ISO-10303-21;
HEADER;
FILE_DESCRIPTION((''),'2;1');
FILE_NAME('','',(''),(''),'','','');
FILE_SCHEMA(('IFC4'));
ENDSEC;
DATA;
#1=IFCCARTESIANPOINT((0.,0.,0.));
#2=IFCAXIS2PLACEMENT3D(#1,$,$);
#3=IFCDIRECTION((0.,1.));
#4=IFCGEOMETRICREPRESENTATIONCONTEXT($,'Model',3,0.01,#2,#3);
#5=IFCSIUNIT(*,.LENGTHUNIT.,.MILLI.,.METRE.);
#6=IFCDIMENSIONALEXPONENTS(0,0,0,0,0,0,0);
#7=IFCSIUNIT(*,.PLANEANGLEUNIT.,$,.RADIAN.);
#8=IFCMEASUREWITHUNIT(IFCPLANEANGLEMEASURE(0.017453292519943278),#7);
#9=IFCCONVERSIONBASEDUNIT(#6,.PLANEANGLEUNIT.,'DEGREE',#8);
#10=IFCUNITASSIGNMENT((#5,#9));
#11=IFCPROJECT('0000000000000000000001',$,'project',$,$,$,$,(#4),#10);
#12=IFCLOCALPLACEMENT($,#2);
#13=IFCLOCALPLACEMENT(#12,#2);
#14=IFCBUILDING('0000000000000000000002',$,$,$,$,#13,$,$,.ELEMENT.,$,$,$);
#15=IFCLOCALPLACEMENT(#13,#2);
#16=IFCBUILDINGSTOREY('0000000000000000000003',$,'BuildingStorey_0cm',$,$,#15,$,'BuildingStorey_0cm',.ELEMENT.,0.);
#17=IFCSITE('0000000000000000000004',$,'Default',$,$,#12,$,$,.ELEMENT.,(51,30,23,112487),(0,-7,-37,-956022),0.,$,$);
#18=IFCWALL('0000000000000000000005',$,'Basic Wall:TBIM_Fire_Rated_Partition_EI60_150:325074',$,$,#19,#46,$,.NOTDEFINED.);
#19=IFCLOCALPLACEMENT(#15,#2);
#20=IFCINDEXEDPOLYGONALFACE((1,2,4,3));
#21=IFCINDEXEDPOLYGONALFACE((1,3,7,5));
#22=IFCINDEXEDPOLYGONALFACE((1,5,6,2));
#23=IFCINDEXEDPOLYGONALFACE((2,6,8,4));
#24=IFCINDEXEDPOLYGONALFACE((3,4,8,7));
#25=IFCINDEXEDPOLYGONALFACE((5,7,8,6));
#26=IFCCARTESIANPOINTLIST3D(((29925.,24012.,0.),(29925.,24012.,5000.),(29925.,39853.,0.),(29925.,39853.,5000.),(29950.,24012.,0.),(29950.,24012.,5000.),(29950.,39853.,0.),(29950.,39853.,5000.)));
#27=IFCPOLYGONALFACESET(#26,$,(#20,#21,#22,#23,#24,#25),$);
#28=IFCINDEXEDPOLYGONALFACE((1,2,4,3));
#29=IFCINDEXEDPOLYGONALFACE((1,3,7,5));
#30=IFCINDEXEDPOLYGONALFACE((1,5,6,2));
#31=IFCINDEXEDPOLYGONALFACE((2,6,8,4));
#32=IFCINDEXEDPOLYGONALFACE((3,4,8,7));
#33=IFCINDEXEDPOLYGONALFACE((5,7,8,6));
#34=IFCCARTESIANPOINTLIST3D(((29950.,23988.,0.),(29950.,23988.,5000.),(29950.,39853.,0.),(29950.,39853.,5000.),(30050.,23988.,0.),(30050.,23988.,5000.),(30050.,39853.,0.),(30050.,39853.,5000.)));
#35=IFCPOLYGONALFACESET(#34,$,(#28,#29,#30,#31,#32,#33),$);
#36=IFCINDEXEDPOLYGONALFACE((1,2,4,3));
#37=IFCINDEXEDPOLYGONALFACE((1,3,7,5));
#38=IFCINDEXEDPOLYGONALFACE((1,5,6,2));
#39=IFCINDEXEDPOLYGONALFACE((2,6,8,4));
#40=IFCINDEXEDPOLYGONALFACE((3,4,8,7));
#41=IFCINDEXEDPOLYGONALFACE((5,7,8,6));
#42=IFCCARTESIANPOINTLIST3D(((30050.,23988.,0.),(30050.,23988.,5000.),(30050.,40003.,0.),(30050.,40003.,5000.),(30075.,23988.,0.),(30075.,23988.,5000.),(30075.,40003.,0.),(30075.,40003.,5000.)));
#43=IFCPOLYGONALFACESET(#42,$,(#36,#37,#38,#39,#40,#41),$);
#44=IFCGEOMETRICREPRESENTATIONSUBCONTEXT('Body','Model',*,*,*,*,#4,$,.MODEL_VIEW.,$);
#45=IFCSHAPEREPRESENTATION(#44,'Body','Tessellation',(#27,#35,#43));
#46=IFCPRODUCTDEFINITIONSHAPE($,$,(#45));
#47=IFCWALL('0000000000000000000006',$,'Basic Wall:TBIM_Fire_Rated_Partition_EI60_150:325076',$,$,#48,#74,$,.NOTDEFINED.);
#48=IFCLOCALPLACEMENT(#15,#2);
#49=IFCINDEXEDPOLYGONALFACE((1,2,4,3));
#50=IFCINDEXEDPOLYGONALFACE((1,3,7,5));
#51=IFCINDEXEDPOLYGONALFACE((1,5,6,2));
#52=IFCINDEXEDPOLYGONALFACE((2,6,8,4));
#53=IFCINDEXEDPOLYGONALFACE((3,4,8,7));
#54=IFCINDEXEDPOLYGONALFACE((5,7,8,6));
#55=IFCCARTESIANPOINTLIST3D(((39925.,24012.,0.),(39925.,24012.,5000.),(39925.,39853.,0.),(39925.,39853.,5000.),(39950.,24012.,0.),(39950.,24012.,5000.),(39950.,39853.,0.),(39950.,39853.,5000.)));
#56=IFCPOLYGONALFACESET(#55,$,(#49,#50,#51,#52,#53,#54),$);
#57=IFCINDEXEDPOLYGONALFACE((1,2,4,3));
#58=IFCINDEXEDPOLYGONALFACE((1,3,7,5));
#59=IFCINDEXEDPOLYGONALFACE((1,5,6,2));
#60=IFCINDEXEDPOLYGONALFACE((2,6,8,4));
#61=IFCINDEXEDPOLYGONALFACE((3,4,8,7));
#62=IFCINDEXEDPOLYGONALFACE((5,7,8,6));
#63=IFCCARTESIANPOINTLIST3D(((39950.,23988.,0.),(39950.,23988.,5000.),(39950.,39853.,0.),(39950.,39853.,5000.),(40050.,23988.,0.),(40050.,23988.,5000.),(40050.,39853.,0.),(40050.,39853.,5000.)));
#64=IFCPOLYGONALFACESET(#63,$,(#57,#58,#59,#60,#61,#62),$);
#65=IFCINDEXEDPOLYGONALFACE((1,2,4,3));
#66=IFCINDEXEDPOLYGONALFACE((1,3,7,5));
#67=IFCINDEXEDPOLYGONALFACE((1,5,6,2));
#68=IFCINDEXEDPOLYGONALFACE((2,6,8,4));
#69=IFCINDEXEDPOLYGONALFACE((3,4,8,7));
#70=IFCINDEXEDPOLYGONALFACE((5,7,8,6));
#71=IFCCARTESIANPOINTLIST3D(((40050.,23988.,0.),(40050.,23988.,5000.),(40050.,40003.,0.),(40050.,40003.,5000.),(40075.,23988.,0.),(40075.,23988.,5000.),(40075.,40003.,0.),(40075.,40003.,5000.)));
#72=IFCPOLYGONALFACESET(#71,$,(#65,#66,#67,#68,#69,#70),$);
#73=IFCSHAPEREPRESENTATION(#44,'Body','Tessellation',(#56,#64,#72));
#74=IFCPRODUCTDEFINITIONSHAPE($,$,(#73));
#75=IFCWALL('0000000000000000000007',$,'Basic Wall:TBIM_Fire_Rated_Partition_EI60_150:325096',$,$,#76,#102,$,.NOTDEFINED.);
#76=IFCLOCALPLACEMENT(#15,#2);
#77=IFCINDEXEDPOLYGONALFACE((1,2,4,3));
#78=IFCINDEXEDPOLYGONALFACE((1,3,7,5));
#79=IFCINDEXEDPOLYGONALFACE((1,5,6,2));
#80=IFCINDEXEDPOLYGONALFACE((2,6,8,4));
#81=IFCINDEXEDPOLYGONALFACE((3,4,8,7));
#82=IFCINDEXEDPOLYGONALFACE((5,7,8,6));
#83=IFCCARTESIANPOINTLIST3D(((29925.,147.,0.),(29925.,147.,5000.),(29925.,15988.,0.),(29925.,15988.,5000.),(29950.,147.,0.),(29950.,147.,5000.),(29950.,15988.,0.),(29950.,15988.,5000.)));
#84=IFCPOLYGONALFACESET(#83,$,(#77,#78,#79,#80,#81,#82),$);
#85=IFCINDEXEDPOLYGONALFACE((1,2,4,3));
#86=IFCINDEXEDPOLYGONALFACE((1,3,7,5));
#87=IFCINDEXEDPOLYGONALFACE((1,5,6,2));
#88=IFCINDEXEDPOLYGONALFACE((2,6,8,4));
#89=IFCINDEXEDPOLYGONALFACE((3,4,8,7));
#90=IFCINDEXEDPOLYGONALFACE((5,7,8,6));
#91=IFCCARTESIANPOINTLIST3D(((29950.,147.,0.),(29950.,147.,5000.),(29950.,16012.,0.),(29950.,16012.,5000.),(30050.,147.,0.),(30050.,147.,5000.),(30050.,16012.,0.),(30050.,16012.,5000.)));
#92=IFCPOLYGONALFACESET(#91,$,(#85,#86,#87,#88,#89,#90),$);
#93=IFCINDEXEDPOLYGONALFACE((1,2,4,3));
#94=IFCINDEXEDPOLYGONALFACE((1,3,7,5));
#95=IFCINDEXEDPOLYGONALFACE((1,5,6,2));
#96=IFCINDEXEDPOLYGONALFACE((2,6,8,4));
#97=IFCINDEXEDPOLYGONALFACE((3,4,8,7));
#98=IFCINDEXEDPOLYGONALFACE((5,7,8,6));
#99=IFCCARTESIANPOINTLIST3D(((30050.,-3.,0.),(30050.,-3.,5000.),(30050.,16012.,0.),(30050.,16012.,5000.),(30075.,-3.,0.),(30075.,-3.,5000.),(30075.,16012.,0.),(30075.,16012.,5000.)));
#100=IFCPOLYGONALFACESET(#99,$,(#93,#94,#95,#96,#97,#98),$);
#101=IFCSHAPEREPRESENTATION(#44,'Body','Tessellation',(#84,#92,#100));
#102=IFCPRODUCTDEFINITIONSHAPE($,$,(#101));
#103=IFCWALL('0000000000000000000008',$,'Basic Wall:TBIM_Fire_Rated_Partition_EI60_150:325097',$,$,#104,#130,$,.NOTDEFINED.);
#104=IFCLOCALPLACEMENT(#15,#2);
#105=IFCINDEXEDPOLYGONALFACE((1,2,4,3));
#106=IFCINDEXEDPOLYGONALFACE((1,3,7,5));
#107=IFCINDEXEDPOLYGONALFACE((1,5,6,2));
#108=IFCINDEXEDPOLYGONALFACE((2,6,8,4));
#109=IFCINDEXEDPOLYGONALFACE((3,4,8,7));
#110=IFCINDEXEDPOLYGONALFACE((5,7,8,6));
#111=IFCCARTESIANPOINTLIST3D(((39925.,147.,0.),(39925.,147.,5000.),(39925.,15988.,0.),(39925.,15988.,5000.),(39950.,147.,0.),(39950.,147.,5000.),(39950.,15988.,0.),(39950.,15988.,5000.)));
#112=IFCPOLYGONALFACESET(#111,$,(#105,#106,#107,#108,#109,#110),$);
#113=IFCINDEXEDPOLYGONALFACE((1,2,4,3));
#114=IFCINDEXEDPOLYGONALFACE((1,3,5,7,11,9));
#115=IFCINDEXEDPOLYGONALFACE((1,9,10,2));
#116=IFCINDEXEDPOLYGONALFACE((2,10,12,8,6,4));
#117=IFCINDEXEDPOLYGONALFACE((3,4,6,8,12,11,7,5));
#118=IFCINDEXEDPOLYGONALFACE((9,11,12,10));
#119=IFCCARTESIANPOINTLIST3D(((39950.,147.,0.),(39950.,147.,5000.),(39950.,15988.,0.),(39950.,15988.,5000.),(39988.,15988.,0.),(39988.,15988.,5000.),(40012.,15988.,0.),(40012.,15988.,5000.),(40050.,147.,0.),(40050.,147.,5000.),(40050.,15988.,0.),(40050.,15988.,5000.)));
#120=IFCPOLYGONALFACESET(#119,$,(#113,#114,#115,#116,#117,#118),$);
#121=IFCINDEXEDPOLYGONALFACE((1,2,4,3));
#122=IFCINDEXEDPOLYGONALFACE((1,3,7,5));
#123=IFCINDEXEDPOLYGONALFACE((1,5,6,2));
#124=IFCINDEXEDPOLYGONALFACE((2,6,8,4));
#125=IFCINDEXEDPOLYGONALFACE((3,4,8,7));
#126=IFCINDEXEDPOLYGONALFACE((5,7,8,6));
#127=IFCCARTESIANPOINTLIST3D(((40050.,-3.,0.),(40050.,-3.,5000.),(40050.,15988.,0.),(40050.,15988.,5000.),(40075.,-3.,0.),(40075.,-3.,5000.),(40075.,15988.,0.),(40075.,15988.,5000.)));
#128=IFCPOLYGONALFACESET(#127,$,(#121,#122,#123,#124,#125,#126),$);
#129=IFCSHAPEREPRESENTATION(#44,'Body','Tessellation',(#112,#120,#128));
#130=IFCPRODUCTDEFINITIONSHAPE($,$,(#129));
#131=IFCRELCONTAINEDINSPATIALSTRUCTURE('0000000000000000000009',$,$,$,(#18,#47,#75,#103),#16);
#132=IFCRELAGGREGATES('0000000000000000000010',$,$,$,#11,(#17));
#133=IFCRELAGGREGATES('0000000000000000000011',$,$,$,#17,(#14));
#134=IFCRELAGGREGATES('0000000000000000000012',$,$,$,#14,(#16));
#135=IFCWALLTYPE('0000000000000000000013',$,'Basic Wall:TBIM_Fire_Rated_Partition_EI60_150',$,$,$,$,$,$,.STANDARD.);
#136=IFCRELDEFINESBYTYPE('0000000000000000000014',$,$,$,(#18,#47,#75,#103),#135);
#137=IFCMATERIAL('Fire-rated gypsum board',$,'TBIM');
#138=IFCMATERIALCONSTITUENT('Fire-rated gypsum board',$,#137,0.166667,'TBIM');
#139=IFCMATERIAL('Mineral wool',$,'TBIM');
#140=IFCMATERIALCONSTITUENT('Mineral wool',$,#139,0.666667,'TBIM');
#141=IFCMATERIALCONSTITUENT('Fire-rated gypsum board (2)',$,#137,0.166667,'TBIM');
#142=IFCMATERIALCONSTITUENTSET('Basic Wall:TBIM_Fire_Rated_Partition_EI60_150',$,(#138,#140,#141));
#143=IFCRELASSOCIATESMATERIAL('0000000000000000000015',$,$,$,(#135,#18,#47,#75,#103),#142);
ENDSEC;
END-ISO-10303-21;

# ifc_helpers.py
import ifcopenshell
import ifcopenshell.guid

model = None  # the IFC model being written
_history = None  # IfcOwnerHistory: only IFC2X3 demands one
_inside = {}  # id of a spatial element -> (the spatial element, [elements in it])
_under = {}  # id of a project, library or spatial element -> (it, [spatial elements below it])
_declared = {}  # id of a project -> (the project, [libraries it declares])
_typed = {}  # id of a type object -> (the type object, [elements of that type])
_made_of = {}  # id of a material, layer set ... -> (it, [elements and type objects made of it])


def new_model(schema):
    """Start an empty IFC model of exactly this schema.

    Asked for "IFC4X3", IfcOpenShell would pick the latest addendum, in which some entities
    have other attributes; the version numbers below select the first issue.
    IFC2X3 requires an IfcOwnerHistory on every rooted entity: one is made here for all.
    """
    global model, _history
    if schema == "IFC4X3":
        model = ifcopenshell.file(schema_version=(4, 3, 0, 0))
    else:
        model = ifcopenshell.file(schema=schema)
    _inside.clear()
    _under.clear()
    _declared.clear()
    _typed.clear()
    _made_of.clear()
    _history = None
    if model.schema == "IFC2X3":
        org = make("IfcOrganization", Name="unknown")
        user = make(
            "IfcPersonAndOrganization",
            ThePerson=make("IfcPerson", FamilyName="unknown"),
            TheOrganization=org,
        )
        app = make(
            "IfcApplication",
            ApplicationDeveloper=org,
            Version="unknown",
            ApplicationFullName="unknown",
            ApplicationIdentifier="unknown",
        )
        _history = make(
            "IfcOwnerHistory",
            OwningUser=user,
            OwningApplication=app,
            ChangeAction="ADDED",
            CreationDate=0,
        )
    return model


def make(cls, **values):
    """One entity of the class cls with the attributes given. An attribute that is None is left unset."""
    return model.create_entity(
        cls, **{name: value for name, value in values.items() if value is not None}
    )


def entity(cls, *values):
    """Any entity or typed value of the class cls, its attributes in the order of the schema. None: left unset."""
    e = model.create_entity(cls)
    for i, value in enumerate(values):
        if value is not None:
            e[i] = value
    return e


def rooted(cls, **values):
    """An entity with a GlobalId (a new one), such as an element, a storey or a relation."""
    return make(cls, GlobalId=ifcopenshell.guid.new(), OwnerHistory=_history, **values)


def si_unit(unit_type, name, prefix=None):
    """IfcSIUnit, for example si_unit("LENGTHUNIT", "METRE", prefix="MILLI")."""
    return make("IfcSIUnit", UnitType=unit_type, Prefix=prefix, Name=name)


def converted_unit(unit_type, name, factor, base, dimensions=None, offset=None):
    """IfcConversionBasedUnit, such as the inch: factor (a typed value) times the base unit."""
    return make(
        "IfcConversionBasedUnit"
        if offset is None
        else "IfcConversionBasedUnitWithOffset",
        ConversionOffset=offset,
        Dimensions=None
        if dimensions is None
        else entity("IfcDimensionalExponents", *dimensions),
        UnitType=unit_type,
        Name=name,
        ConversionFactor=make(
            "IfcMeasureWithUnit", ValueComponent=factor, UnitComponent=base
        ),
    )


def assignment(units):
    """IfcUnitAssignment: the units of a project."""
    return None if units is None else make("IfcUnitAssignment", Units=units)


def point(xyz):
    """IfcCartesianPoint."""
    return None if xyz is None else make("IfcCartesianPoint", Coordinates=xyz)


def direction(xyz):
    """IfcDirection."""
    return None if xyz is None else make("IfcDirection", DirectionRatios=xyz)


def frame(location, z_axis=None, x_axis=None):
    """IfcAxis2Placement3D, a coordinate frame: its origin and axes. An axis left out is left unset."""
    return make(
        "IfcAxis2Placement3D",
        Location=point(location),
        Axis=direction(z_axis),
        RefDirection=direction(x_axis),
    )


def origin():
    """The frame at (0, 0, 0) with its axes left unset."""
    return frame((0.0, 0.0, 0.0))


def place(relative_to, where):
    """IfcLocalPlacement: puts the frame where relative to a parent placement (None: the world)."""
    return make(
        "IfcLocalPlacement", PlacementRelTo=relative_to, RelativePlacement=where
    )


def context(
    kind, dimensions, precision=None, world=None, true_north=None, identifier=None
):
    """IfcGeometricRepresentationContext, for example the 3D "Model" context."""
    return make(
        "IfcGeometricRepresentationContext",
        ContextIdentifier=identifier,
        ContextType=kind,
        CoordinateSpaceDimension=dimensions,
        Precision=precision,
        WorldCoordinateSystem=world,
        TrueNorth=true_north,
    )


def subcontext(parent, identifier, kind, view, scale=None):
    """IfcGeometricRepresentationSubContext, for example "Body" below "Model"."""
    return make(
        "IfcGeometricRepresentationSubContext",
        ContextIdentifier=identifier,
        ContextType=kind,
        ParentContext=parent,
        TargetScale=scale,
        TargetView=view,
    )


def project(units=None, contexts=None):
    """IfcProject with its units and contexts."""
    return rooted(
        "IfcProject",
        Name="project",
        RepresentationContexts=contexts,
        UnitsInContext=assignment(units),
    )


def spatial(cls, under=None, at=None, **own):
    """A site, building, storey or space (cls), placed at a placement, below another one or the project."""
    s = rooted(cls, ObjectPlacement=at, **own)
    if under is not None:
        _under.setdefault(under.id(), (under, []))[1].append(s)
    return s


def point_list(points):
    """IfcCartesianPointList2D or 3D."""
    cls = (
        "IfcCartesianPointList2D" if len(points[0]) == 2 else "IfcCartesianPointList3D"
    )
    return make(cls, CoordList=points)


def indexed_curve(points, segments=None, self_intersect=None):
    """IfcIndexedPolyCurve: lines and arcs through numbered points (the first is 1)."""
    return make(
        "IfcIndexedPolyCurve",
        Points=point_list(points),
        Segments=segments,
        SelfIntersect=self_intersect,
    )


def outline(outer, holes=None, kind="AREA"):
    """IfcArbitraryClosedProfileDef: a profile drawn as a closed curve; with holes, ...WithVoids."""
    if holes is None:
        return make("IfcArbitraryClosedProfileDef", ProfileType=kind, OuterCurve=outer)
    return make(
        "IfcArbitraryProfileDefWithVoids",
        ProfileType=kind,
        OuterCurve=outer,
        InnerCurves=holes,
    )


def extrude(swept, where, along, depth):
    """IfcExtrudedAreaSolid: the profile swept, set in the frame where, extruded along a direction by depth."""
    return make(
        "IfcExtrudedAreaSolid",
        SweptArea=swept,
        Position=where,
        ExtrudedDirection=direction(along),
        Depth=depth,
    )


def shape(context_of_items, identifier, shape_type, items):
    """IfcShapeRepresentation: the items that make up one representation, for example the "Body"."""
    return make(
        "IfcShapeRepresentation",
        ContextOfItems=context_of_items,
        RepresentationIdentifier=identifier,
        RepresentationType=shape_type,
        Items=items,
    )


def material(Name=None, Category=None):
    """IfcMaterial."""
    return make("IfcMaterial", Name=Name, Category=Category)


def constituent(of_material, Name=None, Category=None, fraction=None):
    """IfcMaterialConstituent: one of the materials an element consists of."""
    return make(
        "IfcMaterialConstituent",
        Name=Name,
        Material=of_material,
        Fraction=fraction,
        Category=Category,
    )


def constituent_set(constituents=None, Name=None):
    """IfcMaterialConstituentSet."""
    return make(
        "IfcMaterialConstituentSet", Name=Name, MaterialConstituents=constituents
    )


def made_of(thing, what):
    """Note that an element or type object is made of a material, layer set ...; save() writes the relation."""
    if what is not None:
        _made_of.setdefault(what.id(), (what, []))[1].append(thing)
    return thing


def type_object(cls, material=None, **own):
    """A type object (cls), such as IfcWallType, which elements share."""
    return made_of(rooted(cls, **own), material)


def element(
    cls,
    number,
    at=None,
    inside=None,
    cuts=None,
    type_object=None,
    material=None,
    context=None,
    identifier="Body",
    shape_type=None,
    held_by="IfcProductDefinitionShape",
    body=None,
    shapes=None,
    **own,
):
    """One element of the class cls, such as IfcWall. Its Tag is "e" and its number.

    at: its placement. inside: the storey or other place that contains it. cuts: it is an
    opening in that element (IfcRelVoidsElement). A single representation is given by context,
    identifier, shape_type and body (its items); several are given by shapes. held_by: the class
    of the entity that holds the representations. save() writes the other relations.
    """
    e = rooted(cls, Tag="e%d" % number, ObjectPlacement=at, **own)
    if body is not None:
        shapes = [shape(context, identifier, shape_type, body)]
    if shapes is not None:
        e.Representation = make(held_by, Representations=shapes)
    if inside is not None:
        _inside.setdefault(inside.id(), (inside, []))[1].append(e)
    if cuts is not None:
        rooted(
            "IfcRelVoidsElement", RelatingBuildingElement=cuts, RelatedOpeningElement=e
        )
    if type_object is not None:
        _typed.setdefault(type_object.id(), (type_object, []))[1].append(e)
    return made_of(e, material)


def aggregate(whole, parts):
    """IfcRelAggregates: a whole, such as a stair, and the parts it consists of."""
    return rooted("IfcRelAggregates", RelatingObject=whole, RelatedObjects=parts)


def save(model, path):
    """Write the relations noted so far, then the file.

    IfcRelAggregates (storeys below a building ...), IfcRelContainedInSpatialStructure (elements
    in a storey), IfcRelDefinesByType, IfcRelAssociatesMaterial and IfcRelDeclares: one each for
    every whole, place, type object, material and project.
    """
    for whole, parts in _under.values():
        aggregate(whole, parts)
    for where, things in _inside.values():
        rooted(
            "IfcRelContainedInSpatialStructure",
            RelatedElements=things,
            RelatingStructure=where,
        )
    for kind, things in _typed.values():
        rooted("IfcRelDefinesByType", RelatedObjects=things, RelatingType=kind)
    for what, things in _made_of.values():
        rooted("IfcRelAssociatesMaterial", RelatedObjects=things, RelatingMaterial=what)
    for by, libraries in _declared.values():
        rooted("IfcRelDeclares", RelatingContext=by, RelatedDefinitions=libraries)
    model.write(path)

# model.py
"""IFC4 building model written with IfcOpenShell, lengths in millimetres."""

from ifc_helpers import new_model, entity, si_unit, converted_unit, direction, frame, origin, place, context, subcontext, project, spatial, indexed_curve, outline, extrude, material, constituent, constituent_set, type_object, element, save


model = new_model("IFC4")

# Units and contexts
model_context = context("Model", 3, precision=0.01, world=origin(), true_north=direction((0.0, 1.0)))
body_context = subcontext(model_context, "Body", "Model", "MODEL_VIEW")
ifc_project = project(units=[si_unit("LENGTHUNIT", "METRE", prefix="MILLI"), converted_unit("PLANEANGLEUNIT", "DEGREE", entity("IfcPlaneAngleMeasure", 0.017453292519943278), si_unit("PLANEANGLEUNIT", "RADIAN"), dimensions=[0, 0, 0, 0, 0, 0, 0])], contexts=[model_context])

# Site, building, storey
site_placement = place(None, origin())
site = spatial("IfcSite", under=ifc_project, at=site_placement, Name="Default", CompositionType="ELEMENT", RefLatitude=(51, 30, 23, 112487), RefLongitude=(0, -7, -37, -956022), RefElevation=0.0)
building_placement = place(site_placement, origin())
building = spatial("IfcBuilding", under=site, at=building_placement, CompositionType="ELEMENT")
storey_placement = place(building_placement, origin())
storey = spatial("IfcBuildingStorey", under=building, at=storey_placement, Name="BuildingStorey_0cm", LongName="BuildingStorey_0cm", CompositionType="ELEMENT", Elevation=0.0)

# Shared definitions
ifc_material_1 = material(Name="Mineral wool", Category="TBIM")

# Walls
ifc_material_2 = material(Name="Fire-rated gypsum board", Category="TBIM")
ifc_constituent_1 = constituent(ifc_material_2, Name="Fire-rated gypsum board", Category="TBIM", fraction=0.166667)
ifc_constituent_2 = constituent(ifc_material_1, Name="Mineral wool", Category="TBIM", fraction=0.666667)
ifc_constituent_3 = constituent(ifc_material_2, Name="Fire-rated gypsum board (2)", Category="TBIM", fraction=0.166667)
ifc_constituent_set_1 = constituent_set(constituents=[ifc_constituent_1, ifc_constituent_2, ifc_constituent_3], Name="Basic Wall:TBIM_Fire_Rated_Partition_EI60_150")
wall_type_1 = type_object("IfcWallType", Name="Basic Wall:TBIM_Fire_Rated_Partition_EI60_150", PredefinedType="STANDARD", material=ifc_constituent_set_1)
wall_1_placement = place(storey_placement, frame((30000.0, 24012.0, 0.0), z_axis=(0.0, 0.0, 1.0), x_axis=(0.0, 1.0, 0.0)))
element("IfcWall", 1, at=wall_1_placement, inside=storey, type_object=wall_type_1, material=ifc_constituent_set_1, Name="Basic Wall:TBIM_Fire_Rated_Partition_EI60_150:325074", PredefinedType="NOTDEFINED", context=body_context, shape_type="SweptSolid", body=[
    extrude(outline(indexed_curve([(-12.5, -7920.5), (12.5, -7920.5), (12.5, 7920.5), (-12.5, 7920.5), (-12.5, -7920.5)], self_intersect=False)), frame((7920.5, 62.5, 0.0), z_axis=(0.0, 0.0, 1.0), x_axis=(0.0, -1.0, 0.0)), (0.0, 0.0, 1.0), 5000.0),
    extrude(outline(indexed_curve([(-7932.5, -50.0), (7932.5, -50.0), (7932.5, 50.0), (-7932.5, 50.0), (-7932.5, -50.0)], self_intersect=False)), frame((7908.5, 0.0, 0.0)), (0.0, 0.0, 1.0), 5000.0),
    extrude(outline(indexed_curve([(-12.5, -8007.5), (12.5, -8007.5), (12.5, 8007.5), (-12.5, 8007.5), (-12.5, -8007.5)], self_intersect=False)), frame((7983.5, -62.5, 0.0), z_axis=(0.0, 0.0, 1.0), x_axis=(0.0, 1.0, 0.0)), (0.0, 0.0, 1.0), 5000.0),
])
wall_2_placement = place(storey_placement, frame((40000.0, 24012.0, 0.0), z_axis=(0.0, 0.0, 1.0), x_axis=(0.0, 1.0, 0.0)))
element("IfcWall", 2, at=wall_2_placement, inside=storey, type_object=wall_type_1, material=ifc_constituent_set_1, Name="Basic Wall:TBIM_Fire_Rated_Partition_EI60_150:325076", PredefinedType="NOTDEFINED", context=body_context, shape_type="SweptSolid", body=[
    extrude(outline(indexed_curve([(-12.5, -7920.5), (12.5, -7920.5), (12.5, 7920.5), (-12.5, 7920.5), (-12.5, -7920.5)], self_intersect=False)), frame((7920.5, 62.5, 0.0), z_axis=(0.0, 0.0, 1.0), x_axis=(0.0, -1.0, 0.0)), (0.0, 0.0, 1.0), 5000.0),
    extrude(outline(indexed_curve([(-7932.5, -50.0), (7932.5, -50.0), (7932.5, 50.0), (-7932.5, 50.0), (-7932.5, -50.0)], self_intersect=False)), frame((7908.5, 0.0, 0.0)), (0.0, 0.0, 1.0), 5000.0),
    extrude(outline(indexed_curve([(-12.5, -8007.5), (12.5, -8007.5), (12.5, 8007.5), (-12.5, 8007.5), (-12.5, -8007.5)], self_intersect=False)), frame((7983.5, -62.5, 0.0), z_axis=(0.0, 0.0, 1.0), x_axis=(0.0, 1.0, 0.0)), (0.0, 0.0, 1.0), 5000.0),
])
wall_3_placement = place(storey_placement, frame((30000.0, 147.0, 0.0), z_axis=(0.0, 0.0, 1.0), x_axis=(0.0, 1.0, 0.0)))
element("IfcWall", 3, at=wall_3_placement, inside=storey, type_object=wall_type_1, material=ifc_constituent_set_1, Name="Basic Wall:TBIM_Fire_Rated_Partition_EI60_150:325096", PredefinedType="NOTDEFINED", context=body_context, shape_type="SweptSolid", body=[
    extrude(outline(indexed_curve([(-12.5, -7920.5), (12.5, -7920.5), (12.5, 7920.5), (-12.5, 7920.5), (-12.5, -7920.5)], self_intersect=False)), frame((7920.5, 62.5, 0.0), z_axis=(0.0, 0.0, 1.0), x_axis=(0.0, -1.0, 0.0)), (0.0, 0.0, 1.0), 5000.0),
    extrude(outline(indexed_curve([(-7932.5, -50.0), (7932.5, -50.0), (7932.5, 50.0), (-7932.5, 50.0), (-7932.5, -50.0)], self_intersect=False)), frame((7932.5, 0.0, 0.0)), (0.0, 0.0, 1.0), 5000.0),
    extrude(outline(indexed_curve([(-12.5, -8007.5), (12.5, -8007.5), (12.5, 8007.5), (-12.5, 8007.5), (-12.5, -8007.5)], self_intersect=False)), frame((7857.5, -62.5, 0.0), z_axis=(0.0, 0.0, 1.0), x_axis=(0.0, 1.0, 0.0)), (0.0, 0.0, 1.0), 5000.0),
])
wall_4_placement = place(storey_placement, frame((40000.0, 147.0, 0.0), z_axis=(0.0, 0.0, 1.0), x_axis=(0.0, 1.0, 0.0)))
element("IfcWall", 4, at=wall_4_placement, inside=storey, type_object=wall_type_1, material=ifc_constituent_set_1, Name="Basic Wall:TBIM_Fire_Rated_Partition_EI60_150:325097", PredefinedType="NOTDEFINED", context=body_context, shape_type="SweptSolid", body=[
    extrude(outline(indexed_curve([(-12.5, -7920.5), (12.5, -7920.5), (12.5, 7920.5), (-12.5, 7920.5), (-12.5, -7920.5)], self_intersect=False)), frame((7920.5, 62.5, 0.0), z_axis=(0.0, 0.0, 1.0), x_axis=(0.0, -1.0, 0.0)), (0.0, 0.0, 1.0), 5000.0),
    extrude(outline(indexed_curve([(12.0, -5280.3), (50.0, -5280.3), (50.0, 10560.7), (-50.0, 10560.7), (-50.0, -5280.3), (-12.0, -5280.3), (12.0, -5280.3)], self_intersect=False)), frame((10560.7, 0.0, 0.0), z_axis=(0.0, 0.0, 1.0), x_axis=(0.0, 1.0, 0.0)), (0.0, 0.0, 1.0), 5000.0),
    extrude(outline(indexed_curve([(-12.5, -7995.5), (12.5, -7995.5), (12.5, 7995.5), (-12.5, 7995.5), (-12.5, -7995.5)], self_intersect=False)), frame((7845.5, -62.5, 0.0), z_axis=(0.0, 0.0, 1.0), x_axis=(0.0, 1.0, 0.0)), (0.0, 0.0, 1.0), 5000.0),
])

save(model, "model.ifc")
